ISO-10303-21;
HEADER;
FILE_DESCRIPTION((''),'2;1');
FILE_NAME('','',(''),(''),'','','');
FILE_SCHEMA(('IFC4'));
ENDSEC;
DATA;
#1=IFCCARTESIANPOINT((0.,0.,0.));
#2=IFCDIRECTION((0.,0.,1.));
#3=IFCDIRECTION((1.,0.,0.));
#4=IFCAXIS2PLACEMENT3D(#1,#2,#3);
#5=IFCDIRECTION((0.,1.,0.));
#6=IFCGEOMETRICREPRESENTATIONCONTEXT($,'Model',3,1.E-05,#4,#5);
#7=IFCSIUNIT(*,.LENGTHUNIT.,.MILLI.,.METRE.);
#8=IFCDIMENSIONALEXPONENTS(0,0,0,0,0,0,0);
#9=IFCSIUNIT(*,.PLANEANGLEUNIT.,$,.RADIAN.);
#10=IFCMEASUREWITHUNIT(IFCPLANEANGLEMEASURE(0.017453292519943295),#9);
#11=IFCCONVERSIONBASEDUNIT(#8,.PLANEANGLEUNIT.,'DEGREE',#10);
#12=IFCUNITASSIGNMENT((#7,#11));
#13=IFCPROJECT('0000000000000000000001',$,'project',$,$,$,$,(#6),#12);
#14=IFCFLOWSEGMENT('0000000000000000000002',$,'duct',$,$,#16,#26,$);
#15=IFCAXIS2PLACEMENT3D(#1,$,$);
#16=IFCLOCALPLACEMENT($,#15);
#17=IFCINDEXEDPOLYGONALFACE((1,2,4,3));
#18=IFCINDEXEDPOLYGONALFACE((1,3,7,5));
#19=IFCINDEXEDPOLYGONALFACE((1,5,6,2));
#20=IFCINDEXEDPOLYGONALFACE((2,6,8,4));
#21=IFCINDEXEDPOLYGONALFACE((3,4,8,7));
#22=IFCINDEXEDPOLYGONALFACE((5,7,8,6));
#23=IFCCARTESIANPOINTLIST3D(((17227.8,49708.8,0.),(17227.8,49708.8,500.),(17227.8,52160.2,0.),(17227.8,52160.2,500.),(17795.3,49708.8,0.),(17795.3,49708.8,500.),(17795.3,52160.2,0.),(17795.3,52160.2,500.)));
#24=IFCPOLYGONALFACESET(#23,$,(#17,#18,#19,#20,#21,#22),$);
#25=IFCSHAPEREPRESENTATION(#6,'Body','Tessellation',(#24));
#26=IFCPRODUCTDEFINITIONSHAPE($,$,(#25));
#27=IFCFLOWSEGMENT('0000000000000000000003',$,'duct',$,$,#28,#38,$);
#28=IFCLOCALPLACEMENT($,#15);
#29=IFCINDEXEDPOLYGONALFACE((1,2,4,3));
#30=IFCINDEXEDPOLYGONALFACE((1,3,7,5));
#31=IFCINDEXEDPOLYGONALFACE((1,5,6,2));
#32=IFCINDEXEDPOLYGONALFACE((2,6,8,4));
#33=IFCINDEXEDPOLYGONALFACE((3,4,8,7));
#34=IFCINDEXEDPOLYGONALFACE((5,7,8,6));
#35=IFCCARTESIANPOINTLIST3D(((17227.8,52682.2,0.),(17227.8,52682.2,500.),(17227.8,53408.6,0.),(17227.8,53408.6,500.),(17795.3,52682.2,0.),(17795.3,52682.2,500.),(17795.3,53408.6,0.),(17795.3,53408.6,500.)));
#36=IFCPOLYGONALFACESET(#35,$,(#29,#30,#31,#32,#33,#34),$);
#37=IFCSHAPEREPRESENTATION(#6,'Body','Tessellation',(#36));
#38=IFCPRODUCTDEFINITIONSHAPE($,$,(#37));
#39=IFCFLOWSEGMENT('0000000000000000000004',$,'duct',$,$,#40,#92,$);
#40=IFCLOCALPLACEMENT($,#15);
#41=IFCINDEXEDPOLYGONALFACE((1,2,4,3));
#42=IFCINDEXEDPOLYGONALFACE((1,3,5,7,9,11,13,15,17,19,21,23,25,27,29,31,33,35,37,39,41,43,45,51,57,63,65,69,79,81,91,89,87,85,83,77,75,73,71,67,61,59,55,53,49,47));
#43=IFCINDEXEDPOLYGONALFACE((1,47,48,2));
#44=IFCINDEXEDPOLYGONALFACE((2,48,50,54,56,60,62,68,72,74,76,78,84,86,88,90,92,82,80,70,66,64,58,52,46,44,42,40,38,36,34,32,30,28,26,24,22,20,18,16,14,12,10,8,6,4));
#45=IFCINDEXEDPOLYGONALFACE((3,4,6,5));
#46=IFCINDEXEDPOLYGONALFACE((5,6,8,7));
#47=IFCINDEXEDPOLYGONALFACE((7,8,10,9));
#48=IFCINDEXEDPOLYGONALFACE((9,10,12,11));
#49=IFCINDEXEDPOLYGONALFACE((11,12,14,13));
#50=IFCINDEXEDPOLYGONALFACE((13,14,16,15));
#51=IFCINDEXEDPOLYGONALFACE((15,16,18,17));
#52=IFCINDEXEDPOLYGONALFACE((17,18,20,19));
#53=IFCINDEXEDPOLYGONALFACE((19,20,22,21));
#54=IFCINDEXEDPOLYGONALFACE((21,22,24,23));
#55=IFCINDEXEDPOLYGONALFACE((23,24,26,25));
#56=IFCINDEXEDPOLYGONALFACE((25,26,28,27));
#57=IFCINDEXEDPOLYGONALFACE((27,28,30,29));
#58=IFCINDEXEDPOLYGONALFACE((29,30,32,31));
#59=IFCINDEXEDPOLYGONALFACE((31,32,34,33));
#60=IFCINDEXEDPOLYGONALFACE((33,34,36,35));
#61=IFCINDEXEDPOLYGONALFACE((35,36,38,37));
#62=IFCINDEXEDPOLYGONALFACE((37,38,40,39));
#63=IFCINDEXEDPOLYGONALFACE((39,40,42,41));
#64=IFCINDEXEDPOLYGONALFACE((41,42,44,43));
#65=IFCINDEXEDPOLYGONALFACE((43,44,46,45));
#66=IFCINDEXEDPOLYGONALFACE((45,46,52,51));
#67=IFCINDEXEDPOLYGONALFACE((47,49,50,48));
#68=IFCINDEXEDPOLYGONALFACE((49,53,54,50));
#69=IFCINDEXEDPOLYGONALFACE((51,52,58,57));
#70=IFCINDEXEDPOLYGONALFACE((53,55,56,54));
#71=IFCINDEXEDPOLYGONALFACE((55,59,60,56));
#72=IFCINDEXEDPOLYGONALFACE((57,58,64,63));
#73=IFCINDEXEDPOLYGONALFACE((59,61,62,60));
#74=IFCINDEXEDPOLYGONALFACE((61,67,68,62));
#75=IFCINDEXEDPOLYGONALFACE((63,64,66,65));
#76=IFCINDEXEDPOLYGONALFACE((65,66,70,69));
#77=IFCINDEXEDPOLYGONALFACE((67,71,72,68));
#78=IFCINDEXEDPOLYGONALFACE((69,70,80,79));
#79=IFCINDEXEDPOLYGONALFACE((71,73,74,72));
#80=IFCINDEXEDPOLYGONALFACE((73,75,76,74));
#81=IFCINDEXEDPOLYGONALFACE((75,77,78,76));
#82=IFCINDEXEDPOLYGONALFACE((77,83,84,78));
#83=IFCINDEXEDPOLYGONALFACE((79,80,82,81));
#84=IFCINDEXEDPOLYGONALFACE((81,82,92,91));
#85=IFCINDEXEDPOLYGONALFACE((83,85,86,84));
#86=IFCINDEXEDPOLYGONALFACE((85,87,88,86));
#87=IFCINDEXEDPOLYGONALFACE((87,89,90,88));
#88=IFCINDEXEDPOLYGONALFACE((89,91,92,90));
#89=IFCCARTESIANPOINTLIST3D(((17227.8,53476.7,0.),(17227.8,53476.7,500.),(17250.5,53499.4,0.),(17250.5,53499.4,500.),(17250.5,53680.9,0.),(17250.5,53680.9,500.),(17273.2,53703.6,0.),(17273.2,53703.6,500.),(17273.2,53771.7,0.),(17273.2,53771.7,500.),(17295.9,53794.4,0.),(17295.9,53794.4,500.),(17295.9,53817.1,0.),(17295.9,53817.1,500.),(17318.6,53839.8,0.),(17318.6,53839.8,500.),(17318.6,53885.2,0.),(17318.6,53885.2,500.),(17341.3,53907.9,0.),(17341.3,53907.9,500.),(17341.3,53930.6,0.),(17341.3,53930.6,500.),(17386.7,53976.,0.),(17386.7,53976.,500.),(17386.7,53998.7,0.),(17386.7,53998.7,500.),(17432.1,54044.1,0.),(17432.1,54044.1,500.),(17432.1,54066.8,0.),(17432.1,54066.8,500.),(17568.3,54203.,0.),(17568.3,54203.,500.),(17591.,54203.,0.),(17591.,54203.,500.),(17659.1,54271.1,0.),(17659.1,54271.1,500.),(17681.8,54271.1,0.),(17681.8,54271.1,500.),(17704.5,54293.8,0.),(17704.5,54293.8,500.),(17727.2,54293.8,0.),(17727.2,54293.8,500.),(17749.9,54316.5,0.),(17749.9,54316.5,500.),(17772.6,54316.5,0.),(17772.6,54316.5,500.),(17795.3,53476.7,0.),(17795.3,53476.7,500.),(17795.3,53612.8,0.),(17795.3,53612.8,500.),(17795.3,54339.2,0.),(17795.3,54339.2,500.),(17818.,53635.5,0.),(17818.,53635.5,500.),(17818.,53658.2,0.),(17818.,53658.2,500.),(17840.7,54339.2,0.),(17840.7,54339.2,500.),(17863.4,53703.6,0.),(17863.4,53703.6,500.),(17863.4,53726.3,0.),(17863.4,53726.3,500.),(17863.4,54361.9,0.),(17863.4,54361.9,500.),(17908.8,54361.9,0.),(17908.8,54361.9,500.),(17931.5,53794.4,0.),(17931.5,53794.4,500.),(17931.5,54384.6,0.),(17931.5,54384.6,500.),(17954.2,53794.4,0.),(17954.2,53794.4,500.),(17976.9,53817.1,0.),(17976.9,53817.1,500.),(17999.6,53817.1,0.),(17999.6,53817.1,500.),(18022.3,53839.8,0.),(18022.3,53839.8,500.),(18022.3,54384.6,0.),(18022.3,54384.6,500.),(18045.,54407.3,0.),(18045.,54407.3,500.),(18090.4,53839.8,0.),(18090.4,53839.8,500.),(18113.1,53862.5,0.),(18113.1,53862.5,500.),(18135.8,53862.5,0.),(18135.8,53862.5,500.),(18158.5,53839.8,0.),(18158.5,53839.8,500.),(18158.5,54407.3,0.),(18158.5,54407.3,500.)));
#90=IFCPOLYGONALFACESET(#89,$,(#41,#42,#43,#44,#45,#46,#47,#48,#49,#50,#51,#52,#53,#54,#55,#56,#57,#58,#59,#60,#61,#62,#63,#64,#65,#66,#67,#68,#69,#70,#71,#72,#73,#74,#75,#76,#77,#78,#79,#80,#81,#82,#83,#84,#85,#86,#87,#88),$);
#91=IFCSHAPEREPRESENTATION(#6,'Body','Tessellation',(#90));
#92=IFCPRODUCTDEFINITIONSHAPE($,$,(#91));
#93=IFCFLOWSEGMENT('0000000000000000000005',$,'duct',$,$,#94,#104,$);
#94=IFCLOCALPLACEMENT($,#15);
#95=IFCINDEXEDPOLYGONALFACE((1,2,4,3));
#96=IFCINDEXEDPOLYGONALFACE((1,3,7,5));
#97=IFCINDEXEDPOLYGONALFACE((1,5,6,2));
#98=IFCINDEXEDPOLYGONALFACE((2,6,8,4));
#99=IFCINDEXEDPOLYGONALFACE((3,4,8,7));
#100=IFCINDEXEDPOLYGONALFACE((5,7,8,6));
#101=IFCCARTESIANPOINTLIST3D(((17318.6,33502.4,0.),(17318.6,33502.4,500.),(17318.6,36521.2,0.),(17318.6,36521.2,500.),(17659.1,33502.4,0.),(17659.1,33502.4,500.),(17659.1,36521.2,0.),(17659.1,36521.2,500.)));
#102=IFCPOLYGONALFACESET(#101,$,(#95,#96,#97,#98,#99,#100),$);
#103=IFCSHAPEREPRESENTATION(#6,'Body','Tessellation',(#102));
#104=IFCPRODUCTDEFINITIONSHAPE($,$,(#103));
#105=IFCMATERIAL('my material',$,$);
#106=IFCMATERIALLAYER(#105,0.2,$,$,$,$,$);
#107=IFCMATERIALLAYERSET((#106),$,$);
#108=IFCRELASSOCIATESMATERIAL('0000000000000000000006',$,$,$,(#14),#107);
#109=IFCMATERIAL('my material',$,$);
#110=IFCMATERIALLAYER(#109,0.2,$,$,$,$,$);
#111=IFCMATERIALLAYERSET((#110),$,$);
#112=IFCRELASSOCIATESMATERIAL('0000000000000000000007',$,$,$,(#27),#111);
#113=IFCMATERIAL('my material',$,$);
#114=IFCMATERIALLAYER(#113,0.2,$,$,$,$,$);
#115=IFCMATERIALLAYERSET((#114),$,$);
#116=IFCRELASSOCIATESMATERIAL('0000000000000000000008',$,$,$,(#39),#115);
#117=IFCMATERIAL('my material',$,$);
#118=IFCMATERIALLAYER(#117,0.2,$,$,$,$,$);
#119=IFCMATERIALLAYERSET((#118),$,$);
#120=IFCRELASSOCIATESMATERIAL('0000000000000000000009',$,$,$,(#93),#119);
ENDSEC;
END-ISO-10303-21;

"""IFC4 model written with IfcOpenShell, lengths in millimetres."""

from ifc_helpers import new_model, entity, si_unit, converted_unit, direction, origin_with_axes, place, context, project, polyline, outline, extrude, material, layer, layer_set, layer_usage, element, save


model = new_model("IFC4")

# Units and contexts
model_context = context("Model", 3, precision=1e-05, world=origin_with_axes(), true_north=direction((0.0, 1.0, 0.0)))
ifc_project = project(units=[si_unit("LENGTHUNIT", "METRE", prefix="MILLI"), converted_unit("PLANEANGLEUNIT", "DEGREE", entity("IfcPlaneAngleMeasure", 0.017453292519943295), si_unit("PLANEANGLEUNIT", "RADIAN"), dimensions=[0, 0, 0, 0, 0, 0, 0])], contexts=[model_context])

# Flow segments
ifc_material_1 = material(Name="my material")
ifc_layer_1 = layer(ifc_material_1, 0.2)
ifc_layer_set_1 = layer_set([ifc_layer_1])
ifc_layer_usage_1 = layer_usage(ifc_layer_set_1, "AXIS2", "POSITIVE", -0.1)
flow_segment_1_placement = place(None, origin_with_axes())
element("IfcFlowSegment", 1, at=flow_segment_1_placement, material=ifc_layer_usage_1, Name="duct", context=model_context, shape_type="SweptSolid", body=[
    extrude(outline(polyline([(17227.8, 49708.8), (17795.3, 49708.8), (17795.3, 52160.2), (17227.8, 52160.2), (17227.8, 49708.8)])), origin_with_axes(), (0.0, 0.0, 1.0), 500.0),
])
ifc_material_2 = material(Name="my material")
ifc_layer_2 = layer(ifc_material_2, 0.2)
ifc_layer_set_2 = layer_set([ifc_layer_2])
ifc_layer_usage_2 = layer_usage(ifc_layer_set_2, "AXIS2", "POSITIVE", -0.1)
flow_segment_2_placement = place(None, origin_with_axes())
element("IfcFlowSegment", 2, at=flow_segment_2_placement, material=ifc_layer_usage_2, Name="duct", context=model_context, shape_type="SweptSolid", body=[
    extrude(outline(polyline([(17227.8, 52682.2), (17795.3, 52682.2), (17795.3, 53408.6), (17227.8, 53408.6), (17227.8, 52682.2)])), origin_with_axes(), (0.0, 0.0, 1.0), 500.0),
])
ifc_material_3 = material(Name="my material")
ifc_layer_3 = layer(ifc_material_3, 0.2)
ifc_layer_set_3 = layer_set([ifc_layer_3])
ifc_layer_usage_3 = layer_usage(ifc_layer_set_3, "AXIS2", "POSITIVE", -0.1)
flow_segment_3_placement = place(None, origin_with_axes())
element("IfcFlowSegment", 3, at=flow_segment_3_placement, material=ifc_layer_usage_3, Name="duct", context=model_context, shape_type="SweptSolid", body=[
    extrude(outline(polyline([(17227.8, 53476.7), (17795.3, 53476.7), (17795.3, 53612.8), (17818.0, 53635.5), (17818.0, 53658.2), (17863.4, 53703.6), (17863.4, 53726.3), (17931.5, 53794.4), (17954.2, 53794.4), (17976.9, 53817.1), (17999.6, 53817.1), (18022.3, 53839.8), (18090.4, 53839.8), (18113.1, 53862.5), (18135.8, 53862.5), (18158.5, 53839.8), (18158.5, 54407.3), (18045.0, 54407.3), (18022.3, 54384.6), (17931.5, 54384.6), (17908.8, 54361.9), (17863.4, 54361.9), (17840.7, 54339.2), (17795.3, 54339.2), (17772.6, 54316.5), (17749.9, 54316.5), (17727.2, 54293.8), (17704.5, 54293.8), (17681.8, 54271.1), (17659.1, 54271.1), (17591.0, 54203.0), (17568.3, 54203.0), (17432.1, 54066.8), (17432.1, 54044.1), (17386.7, 53998.7), (17386.7, 53976.0), (17341.3, 53930.6), (17341.3, 53907.9), (17318.6, 53885.2), (17318.6, 53839.8), (17295.9, 53817.1), (17295.9, 53794.4), (17273.2, 53771.7), (17273.2, 53703.6), (17250.5, 53680.9), (17250.5, 53499.4), (17227.8, 53476.7)])), origin_with_axes(), (0.0, 0.0, 1.0), 500.0),
])
ifc_material_4 = material(Name="my material")
ifc_layer_4 = layer(ifc_material_4, 0.2)
ifc_layer_set_4 = layer_set([ifc_layer_4])
ifc_layer_usage_4 = layer_usage(ifc_layer_set_4, "AXIS2", "POSITIVE", -0.1)
flow_segment_4_placement = place(None, origin_with_axes())
element("IfcFlowSegment", 4, at=flow_segment_4_placement, material=ifc_layer_usage_4, Name="duct", context=model_context, shape_type="SweptSolid", body=[
    extrude(outline(polyline([(17318.6, 33502.4), (17659.1, 33502.4), (17659.1, 36521.2), (17318.6, 36521.2), (17318.6, 33502.4)])), origin_with_axes(), (0.0, 0.0, 1.0), 500.0),
])

save(model, "model.ifc")
